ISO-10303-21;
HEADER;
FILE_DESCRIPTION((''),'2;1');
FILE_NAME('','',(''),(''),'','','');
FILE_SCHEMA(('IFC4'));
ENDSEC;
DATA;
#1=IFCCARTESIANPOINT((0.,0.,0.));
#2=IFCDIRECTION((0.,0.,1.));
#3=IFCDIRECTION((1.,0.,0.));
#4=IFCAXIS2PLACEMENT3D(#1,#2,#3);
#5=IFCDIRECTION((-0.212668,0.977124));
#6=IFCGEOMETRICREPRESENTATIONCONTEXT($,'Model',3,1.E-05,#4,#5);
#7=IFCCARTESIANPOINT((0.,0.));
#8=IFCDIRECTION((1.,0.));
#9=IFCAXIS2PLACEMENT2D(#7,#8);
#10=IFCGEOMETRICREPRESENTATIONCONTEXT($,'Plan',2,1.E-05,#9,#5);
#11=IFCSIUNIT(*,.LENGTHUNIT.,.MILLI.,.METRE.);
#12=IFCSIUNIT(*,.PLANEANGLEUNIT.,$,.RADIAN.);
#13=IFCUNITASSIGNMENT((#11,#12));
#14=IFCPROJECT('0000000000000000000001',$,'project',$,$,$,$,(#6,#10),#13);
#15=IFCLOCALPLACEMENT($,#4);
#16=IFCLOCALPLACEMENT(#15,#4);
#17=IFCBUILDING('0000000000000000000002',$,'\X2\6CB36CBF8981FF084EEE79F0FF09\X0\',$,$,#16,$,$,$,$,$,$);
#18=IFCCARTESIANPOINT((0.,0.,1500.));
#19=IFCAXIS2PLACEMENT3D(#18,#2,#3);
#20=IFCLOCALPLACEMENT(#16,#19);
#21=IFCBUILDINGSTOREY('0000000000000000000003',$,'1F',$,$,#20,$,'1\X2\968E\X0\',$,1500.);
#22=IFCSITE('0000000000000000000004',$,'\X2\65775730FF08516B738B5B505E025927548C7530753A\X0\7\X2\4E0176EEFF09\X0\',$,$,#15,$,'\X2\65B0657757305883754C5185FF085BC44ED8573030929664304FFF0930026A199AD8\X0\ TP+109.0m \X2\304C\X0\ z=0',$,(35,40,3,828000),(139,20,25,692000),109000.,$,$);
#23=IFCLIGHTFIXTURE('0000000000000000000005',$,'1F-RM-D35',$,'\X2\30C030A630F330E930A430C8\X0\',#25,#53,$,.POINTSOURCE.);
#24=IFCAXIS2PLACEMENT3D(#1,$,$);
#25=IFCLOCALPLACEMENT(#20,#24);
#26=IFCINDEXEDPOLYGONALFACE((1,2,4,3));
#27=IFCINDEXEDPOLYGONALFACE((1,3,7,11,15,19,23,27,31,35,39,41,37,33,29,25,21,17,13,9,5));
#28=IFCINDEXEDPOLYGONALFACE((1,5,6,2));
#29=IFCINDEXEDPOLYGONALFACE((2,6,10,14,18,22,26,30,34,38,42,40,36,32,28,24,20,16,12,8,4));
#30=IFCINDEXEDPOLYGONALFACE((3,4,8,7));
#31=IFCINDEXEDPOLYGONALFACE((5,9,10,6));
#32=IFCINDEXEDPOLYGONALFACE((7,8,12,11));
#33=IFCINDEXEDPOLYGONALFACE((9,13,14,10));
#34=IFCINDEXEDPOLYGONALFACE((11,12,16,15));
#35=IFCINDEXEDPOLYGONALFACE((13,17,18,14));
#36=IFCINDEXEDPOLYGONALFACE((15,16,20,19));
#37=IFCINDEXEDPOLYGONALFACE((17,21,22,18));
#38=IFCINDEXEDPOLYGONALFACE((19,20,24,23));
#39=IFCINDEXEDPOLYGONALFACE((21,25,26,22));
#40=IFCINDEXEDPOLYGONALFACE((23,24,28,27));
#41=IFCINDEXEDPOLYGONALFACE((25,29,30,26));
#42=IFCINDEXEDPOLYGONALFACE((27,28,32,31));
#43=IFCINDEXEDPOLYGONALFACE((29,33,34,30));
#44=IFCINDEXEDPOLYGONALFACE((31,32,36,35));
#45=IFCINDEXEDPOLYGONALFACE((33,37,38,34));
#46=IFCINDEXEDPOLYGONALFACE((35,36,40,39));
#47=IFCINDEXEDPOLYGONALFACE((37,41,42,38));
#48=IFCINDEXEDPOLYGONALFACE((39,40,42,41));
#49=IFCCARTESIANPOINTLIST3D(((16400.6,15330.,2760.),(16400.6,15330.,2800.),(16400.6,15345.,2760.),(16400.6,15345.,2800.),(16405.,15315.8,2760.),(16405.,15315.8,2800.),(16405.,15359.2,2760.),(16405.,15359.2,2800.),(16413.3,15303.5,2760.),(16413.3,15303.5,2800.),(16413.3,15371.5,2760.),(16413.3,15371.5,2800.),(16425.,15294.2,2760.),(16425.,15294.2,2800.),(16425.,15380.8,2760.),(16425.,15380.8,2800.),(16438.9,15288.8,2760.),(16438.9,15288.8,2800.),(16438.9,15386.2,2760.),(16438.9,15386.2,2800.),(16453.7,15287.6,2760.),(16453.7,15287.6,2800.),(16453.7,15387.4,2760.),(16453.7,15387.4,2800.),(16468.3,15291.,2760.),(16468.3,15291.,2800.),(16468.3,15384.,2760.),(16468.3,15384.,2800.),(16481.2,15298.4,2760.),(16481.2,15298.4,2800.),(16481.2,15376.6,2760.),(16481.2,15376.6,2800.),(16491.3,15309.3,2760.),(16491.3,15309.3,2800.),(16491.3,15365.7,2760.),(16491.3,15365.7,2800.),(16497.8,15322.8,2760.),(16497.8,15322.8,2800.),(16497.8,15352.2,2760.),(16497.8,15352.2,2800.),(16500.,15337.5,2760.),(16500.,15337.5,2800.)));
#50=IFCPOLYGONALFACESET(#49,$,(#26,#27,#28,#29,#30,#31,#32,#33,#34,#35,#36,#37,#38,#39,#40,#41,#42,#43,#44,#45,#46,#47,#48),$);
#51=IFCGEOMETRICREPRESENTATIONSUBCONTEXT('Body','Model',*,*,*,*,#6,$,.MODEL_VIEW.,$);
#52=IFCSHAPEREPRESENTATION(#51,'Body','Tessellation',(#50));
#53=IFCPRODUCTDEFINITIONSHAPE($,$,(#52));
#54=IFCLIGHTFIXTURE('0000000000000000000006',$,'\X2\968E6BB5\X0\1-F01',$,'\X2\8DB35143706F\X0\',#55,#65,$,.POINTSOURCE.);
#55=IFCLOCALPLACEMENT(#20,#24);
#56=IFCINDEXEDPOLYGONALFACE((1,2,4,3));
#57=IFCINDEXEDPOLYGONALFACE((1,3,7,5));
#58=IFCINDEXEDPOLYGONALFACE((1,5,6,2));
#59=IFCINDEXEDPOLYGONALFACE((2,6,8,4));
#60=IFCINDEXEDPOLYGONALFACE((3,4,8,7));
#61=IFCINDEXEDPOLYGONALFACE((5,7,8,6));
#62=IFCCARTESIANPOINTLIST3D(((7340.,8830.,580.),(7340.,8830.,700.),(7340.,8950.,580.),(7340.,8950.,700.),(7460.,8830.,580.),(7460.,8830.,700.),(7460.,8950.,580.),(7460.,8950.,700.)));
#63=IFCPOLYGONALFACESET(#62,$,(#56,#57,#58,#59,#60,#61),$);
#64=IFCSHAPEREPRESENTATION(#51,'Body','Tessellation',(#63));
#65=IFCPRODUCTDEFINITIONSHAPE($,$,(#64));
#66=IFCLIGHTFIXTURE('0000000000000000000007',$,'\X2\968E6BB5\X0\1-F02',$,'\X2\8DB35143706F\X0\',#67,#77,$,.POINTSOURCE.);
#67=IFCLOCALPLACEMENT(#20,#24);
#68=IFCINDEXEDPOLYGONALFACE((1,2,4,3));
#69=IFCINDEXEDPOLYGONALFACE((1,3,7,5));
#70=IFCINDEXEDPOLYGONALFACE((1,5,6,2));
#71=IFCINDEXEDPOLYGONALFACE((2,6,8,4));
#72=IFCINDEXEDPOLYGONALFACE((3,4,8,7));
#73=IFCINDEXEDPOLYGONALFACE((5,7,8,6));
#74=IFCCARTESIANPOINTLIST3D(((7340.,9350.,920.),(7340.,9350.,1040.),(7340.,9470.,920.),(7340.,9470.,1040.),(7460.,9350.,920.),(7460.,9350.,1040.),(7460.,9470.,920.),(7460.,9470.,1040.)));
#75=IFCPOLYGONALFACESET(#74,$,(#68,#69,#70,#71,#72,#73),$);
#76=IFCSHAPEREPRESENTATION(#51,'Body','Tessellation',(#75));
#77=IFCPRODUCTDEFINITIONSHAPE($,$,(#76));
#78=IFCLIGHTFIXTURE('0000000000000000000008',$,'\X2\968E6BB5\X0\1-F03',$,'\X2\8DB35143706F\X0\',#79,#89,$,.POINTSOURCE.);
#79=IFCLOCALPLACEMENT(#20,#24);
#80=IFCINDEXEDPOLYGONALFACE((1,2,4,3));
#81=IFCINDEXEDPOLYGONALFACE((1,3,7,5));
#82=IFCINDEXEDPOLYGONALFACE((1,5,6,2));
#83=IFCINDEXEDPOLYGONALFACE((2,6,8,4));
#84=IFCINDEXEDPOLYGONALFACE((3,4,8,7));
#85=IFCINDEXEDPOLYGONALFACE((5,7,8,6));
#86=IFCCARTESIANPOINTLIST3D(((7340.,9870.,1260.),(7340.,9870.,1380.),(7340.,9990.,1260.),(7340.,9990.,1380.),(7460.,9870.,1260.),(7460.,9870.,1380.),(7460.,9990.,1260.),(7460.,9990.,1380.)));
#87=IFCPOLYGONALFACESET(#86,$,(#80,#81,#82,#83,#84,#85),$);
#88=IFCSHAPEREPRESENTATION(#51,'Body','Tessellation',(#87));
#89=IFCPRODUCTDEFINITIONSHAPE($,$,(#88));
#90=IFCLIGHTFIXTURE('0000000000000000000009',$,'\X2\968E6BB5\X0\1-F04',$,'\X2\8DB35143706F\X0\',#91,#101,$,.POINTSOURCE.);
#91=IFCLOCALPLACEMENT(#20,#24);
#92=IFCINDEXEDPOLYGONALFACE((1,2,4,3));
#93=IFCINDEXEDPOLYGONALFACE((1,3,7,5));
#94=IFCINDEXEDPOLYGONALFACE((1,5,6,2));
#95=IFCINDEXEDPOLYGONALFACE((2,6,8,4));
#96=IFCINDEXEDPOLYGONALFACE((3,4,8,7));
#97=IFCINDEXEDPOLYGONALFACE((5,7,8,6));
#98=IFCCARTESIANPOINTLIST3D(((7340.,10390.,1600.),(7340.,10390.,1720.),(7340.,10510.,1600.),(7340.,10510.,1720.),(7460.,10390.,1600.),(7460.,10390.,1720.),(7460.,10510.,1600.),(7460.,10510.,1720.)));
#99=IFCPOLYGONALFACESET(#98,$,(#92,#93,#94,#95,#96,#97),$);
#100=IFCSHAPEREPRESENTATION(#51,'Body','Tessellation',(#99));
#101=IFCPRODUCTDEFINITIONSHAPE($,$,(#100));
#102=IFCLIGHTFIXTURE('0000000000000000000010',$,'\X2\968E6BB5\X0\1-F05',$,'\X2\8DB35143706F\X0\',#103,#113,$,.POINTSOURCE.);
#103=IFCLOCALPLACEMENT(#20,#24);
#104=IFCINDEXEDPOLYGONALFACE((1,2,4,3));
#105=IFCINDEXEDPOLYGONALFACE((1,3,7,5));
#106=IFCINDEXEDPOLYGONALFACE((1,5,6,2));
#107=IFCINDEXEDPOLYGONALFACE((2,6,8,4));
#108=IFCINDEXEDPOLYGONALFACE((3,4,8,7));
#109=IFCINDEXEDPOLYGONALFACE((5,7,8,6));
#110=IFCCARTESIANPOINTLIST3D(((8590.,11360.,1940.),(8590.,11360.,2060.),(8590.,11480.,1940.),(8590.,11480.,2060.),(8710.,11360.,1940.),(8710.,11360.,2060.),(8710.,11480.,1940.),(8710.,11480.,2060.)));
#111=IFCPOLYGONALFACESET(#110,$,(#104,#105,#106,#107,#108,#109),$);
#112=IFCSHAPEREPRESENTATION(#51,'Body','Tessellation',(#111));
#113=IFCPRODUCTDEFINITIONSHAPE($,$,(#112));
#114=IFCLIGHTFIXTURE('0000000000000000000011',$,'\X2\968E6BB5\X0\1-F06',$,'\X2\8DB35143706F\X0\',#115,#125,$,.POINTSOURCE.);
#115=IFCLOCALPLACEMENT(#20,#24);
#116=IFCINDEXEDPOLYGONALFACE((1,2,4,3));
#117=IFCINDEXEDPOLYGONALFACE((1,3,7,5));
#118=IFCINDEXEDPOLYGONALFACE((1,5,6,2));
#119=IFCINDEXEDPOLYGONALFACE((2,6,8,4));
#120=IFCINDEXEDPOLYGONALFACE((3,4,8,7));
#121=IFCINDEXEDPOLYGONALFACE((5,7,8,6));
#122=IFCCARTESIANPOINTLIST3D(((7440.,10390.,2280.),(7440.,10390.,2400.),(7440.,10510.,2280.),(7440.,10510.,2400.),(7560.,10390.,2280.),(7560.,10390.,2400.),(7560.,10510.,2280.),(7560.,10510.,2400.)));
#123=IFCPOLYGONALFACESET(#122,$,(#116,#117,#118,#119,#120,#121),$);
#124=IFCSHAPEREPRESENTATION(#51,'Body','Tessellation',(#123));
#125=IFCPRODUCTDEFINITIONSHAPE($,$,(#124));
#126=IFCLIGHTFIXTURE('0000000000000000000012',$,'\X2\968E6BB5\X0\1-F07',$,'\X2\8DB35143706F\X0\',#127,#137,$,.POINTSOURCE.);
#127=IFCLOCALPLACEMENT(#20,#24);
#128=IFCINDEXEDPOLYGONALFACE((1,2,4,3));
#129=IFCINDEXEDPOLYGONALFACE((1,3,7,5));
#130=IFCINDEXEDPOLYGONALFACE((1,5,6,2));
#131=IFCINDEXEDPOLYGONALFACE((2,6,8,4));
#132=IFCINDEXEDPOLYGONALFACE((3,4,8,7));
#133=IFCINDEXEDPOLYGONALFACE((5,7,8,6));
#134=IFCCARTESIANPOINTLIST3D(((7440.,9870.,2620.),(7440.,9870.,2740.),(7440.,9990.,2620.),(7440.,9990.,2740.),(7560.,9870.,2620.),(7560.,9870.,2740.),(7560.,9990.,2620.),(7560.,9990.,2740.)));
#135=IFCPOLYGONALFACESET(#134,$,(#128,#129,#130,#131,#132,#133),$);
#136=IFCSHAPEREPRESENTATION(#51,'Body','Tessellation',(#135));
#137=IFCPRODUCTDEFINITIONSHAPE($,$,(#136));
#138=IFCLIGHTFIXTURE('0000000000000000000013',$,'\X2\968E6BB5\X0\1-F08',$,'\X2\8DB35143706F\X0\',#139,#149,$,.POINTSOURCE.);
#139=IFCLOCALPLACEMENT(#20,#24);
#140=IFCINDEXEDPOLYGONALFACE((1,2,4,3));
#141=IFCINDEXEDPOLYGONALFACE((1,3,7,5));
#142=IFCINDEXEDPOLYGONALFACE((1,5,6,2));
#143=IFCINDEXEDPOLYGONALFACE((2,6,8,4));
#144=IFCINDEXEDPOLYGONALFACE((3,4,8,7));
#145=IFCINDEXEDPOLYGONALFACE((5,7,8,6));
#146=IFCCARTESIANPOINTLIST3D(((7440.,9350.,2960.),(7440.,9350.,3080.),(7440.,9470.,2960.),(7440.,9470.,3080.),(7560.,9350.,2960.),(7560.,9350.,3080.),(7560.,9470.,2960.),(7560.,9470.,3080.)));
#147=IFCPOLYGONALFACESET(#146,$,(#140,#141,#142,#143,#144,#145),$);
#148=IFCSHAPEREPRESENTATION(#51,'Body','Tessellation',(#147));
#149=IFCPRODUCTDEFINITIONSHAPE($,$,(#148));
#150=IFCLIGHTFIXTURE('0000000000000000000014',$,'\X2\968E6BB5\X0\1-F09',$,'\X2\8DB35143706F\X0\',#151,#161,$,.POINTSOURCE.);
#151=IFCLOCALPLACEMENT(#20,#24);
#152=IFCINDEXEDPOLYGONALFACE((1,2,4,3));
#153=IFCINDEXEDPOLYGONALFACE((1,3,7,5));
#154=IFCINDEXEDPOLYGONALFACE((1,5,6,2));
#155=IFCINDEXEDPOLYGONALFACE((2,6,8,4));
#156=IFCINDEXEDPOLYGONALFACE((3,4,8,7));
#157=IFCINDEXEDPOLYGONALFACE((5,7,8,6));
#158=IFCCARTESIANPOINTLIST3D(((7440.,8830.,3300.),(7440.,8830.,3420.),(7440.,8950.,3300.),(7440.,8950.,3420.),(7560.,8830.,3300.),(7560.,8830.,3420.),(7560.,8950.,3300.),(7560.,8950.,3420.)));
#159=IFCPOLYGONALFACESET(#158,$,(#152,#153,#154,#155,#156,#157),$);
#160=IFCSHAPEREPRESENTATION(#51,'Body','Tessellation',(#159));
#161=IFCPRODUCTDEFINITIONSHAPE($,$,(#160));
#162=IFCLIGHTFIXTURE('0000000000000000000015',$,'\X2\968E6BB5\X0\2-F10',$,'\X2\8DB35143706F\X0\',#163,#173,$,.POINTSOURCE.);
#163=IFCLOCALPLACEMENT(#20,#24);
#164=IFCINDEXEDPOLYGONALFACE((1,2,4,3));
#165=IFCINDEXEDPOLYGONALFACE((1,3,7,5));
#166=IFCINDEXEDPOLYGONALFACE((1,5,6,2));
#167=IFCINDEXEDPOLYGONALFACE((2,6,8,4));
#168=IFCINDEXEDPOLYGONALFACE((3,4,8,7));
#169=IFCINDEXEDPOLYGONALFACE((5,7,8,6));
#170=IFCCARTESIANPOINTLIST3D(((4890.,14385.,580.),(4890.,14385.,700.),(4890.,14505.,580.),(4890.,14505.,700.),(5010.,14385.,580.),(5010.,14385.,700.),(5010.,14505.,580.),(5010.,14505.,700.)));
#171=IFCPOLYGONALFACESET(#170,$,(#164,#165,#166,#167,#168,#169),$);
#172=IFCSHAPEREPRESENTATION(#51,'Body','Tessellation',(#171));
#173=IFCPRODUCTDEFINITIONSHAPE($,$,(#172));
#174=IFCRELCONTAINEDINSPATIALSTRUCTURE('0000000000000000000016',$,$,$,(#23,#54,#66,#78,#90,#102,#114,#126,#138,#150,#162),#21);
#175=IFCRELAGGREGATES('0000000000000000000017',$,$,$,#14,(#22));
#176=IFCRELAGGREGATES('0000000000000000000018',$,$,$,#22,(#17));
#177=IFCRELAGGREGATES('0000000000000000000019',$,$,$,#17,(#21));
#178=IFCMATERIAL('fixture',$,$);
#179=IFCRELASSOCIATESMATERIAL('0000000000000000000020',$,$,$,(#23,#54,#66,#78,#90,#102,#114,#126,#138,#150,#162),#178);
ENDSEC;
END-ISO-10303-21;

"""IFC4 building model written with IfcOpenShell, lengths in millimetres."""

from ifc_helpers import new_model, si_unit, direction, frame, frame_2d, origin_with_axes, origin_2d_with_axis, place, context, subcontext, project, spatial, rectangle, circle, extrude, material, element, save


model = new_model("IFC4")

# Units and contexts
model_context = context("Model", 3, precision=1e-05, world=origin_with_axes(), true_north=direction((-0.212668, 0.977124)))
plan_context = context("Plan", 2, precision=1e-05, world=origin_2d_with_axis(), true_north=direction((-0.212668, 0.977124)))
body_context = subcontext(model_context, "Body", "Model", "MODEL_VIEW")
ifc_project = project(units=[si_unit("LENGTHUNIT", "METRE", prefix="MILLI"), si_unit("PLANEANGLEUNIT", "RADIAN")], contexts=[model_context, plan_context])

# Site, building, storey
site_placement = place(None, origin_with_axes())
site = spatial("IfcSite", under=ifc_project, at=site_placement, Name="敷地（八王子市大和田町7丁目）", LongName="新敷地境界内（寄付地を除く）。標高 TP+109.0m が z=0", RefLatitude=(35, 40, 3, 828000), RefLongitude=(139, 20, 25, 692000), RefElevation=109000.0)
building_placement = place(site_placement, origin_with_axes())
building = spatial("IfcBuilding", under=site, at=building_placement, Name="河沿要（仮称）")
storey_placement = place(building_placement, frame((0.0, 0.0, 1500.0), z_axis=(0.0, 0.0, 1.0), x_axis=(1.0, 0.0, 0.0)))
storey = spatial("IfcBuildingStorey", under=building, at=storey_placement, Name="1F", LongName="1階", Elevation=1500.0)

# Light fixtures
ifc_material = material(Name="fixture")
light_fixture_1_placement = place(storey_placement, origin_with_axes())
element("IfcLightFixture", 1, at=light_fixture_1_placement, inside=storey, material=ifc_material, Name="1F-RM-D35", ObjectType="ダウンライト", PredefinedType="POINTSOURCE", context=body_context, shape_type="SweptSolid", body=[
    extrude(circle(Radius=50.0, at=frame_2d((16450.0, 15337.5))), frame((0.0, 0.0, 2760.0)), (0.0, 0.0, 1.0), 40.0),
])
light_fixture_2_placement = place(storey_placement, origin_with_axes())
element("IfcLightFixture", 2, at=light_fixture_2_placement, inside=storey, material=ifc_material, Name="階段1-F01", ObjectType="足元灯", PredefinedType="POINTSOURCE", context=body_context, shape_type="SweptSolid", body=[
    extrude(rectangle(XDim=120.0, YDim=120.0, at=frame_2d((7400.0, 8890.0))), frame((0.0, 0.0, 580.0)), (0.0, 0.0, 1.0), 120.0),
])
light_fixture_3_placement = place(storey_placement, origin_with_axes())
element("IfcLightFixture", 3, at=light_fixture_3_placement, inside=storey, material=ifc_material, Name="階段1-F02", ObjectType="足元灯", PredefinedType="POINTSOURCE", context=body_context, shape_type="SweptSolid", body=[
    extrude(rectangle(XDim=120.0, YDim=120.0, at=frame_2d((7400.0, 9410.0))), frame((0.0, 0.0, 920.0)), (0.0, 0.0, 1.0), 120.0),
])
light_fixture_4_placement = place(storey_placement, origin_with_axes())
element("IfcLightFixture", 4, at=light_fixture_4_placement, inside=storey, material=ifc_material, Name="階段1-F03", ObjectType="足元灯", PredefinedType="POINTSOURCE", context=body_context, shape_type="SweptSolid", body=[
    extrude(rectangle(XDim=120.0, YDim=120.0, at=frame_2d((7400.0, 9930.0))), frame((0.0, 0.0, 1260.0)), (0.0, 0.0, 1.0), 120.0),
])
light_fixture_5_placement = place(storey_placement, origin_with_axes())
element("IfcLightFixture", 5, at=light_fixture_5_placement, inside=storey, material=ifc_material, Name="階段1-F04", ObjectType="足元灯", PredefinedType="POINTSOURCE", context=body_context, shape_type="SweptSolid", body=[
    extrude(rectangle(XDim=120.0, YDim=120.0, at=frame_2d((7400.0, 10450.0))), frame((0.0, 0.0, 1600.0)), (0.0, 0.0, 1.0), 120.0),
])
light_fixture_6_placement = place(storey_placement, origin_with_axes())
element("IfcLightFixture", 6, at=light_fixture_6_placement, inside=storey, material=ifc_material, Name="階段1-F05", ObjectType="足元灯", PredefinedType="POINTSOURCE", context=body_context, shape_type="SweptSolid", body=[
    extrude(rectangle(XDim=120.0, YDim=120.0, at=frame_2d((8650.0, 11420.0))), frame((0.0, 0.0, 1940.0)), (0.0, 0.0, 1.0), 120.0),
])
light_fixture_7_placement = place(storey_placement, origin_with_axes())
element("IfcLightFixture", 7, at=light_fixture_7_placement, inside=storey, material=ifc_material, Name="階段1-F06", ObjectType="足元灯", PredefinedType="POINTSOURCE", context=body_context, shape_type="SweptSolid", body=[
    extrude(rectangle(XDim=120.0, YDim=120.0, at=frame_2d((7500.0, 10450.0))), frame((0.0, 0.0, 2280.0)), (0.0, 0.0, 1.0), 120.0),
])
light_fixture_8_placement = place(storey_placement, origin_with_axes())
element("IfcLightFixture", 8, at=light_fixture_8_placement, inside=storey, material=ifc_material, Name="階段1-F07", ObjectType="足元灯", PredefinedType="POINTSOURCE", context=body_context, shape_type="SweptSolid", body=[
    extrude(rectangle(XDim=120.0, YDim=120.0, at=frame_2d((7500.0, 9930.0))), frame((0.0, 0.0, 2620.0)), (0.0, 0.0, 1.0), 120.0),
])
light_fixture_9_placement = place(storey_placement, origin_with_axes())
element("IfcLightFixture", 9, at=light_fixture_9_placement, inside=storey, material=ifc_material, Name="階段1-F08", ObjectType="足元灯", PredefinedType="POINTSOURCE", context=body_context, shape_type="SweptSolid", body=[
    extrude(rectangle(XDim=120.0, YDim=120.0, at=frame_2d((7500.0, 9410.0))), frame((0.0, 0.0, 2960.0)), (0.0, 0.0, 1.0), 120.0),
])
light_fixture_10_placement = place(storey_placement, origin_with_axes())
element("IfcLightFixture", 10, at=light_fixture_10_placement, inside=storey, material=ifc_material, Name="階段1-F09", ObjectType="足元灯", PredefinedType="POINTSOURCE", context=body_context, shape_type="SweptSolid", body=[
    extrude(rectangle(XDim=120.0, YDim=120.0, at=frame_2d((7500.0, 8890.0))), frame((0.0, 0.0, 3300.0)), (0.0, 0.0, 1.0), 120.0),
])
light_fixture_11_placement = place(storey_placement, origin_with_axes())
element("IfcLightFixture", 11, at=light_fixture_11_placement, inside=storey, material=ifc_material, Name="階段2-F10", ObjectType="足元灯", PredefinedType="POINTSOURCE", context=body_context, shape_type="SweptSolid", body=[
    extrude(rectangle(XDim=120.0, YDim=120.0, at=frame_2d((4950.0, 14445.0))), frame((0.0, 0.0, 580.0)), (0.0, 0.0, 1.0), 120.0),
])

save(model, "model.ifc")
